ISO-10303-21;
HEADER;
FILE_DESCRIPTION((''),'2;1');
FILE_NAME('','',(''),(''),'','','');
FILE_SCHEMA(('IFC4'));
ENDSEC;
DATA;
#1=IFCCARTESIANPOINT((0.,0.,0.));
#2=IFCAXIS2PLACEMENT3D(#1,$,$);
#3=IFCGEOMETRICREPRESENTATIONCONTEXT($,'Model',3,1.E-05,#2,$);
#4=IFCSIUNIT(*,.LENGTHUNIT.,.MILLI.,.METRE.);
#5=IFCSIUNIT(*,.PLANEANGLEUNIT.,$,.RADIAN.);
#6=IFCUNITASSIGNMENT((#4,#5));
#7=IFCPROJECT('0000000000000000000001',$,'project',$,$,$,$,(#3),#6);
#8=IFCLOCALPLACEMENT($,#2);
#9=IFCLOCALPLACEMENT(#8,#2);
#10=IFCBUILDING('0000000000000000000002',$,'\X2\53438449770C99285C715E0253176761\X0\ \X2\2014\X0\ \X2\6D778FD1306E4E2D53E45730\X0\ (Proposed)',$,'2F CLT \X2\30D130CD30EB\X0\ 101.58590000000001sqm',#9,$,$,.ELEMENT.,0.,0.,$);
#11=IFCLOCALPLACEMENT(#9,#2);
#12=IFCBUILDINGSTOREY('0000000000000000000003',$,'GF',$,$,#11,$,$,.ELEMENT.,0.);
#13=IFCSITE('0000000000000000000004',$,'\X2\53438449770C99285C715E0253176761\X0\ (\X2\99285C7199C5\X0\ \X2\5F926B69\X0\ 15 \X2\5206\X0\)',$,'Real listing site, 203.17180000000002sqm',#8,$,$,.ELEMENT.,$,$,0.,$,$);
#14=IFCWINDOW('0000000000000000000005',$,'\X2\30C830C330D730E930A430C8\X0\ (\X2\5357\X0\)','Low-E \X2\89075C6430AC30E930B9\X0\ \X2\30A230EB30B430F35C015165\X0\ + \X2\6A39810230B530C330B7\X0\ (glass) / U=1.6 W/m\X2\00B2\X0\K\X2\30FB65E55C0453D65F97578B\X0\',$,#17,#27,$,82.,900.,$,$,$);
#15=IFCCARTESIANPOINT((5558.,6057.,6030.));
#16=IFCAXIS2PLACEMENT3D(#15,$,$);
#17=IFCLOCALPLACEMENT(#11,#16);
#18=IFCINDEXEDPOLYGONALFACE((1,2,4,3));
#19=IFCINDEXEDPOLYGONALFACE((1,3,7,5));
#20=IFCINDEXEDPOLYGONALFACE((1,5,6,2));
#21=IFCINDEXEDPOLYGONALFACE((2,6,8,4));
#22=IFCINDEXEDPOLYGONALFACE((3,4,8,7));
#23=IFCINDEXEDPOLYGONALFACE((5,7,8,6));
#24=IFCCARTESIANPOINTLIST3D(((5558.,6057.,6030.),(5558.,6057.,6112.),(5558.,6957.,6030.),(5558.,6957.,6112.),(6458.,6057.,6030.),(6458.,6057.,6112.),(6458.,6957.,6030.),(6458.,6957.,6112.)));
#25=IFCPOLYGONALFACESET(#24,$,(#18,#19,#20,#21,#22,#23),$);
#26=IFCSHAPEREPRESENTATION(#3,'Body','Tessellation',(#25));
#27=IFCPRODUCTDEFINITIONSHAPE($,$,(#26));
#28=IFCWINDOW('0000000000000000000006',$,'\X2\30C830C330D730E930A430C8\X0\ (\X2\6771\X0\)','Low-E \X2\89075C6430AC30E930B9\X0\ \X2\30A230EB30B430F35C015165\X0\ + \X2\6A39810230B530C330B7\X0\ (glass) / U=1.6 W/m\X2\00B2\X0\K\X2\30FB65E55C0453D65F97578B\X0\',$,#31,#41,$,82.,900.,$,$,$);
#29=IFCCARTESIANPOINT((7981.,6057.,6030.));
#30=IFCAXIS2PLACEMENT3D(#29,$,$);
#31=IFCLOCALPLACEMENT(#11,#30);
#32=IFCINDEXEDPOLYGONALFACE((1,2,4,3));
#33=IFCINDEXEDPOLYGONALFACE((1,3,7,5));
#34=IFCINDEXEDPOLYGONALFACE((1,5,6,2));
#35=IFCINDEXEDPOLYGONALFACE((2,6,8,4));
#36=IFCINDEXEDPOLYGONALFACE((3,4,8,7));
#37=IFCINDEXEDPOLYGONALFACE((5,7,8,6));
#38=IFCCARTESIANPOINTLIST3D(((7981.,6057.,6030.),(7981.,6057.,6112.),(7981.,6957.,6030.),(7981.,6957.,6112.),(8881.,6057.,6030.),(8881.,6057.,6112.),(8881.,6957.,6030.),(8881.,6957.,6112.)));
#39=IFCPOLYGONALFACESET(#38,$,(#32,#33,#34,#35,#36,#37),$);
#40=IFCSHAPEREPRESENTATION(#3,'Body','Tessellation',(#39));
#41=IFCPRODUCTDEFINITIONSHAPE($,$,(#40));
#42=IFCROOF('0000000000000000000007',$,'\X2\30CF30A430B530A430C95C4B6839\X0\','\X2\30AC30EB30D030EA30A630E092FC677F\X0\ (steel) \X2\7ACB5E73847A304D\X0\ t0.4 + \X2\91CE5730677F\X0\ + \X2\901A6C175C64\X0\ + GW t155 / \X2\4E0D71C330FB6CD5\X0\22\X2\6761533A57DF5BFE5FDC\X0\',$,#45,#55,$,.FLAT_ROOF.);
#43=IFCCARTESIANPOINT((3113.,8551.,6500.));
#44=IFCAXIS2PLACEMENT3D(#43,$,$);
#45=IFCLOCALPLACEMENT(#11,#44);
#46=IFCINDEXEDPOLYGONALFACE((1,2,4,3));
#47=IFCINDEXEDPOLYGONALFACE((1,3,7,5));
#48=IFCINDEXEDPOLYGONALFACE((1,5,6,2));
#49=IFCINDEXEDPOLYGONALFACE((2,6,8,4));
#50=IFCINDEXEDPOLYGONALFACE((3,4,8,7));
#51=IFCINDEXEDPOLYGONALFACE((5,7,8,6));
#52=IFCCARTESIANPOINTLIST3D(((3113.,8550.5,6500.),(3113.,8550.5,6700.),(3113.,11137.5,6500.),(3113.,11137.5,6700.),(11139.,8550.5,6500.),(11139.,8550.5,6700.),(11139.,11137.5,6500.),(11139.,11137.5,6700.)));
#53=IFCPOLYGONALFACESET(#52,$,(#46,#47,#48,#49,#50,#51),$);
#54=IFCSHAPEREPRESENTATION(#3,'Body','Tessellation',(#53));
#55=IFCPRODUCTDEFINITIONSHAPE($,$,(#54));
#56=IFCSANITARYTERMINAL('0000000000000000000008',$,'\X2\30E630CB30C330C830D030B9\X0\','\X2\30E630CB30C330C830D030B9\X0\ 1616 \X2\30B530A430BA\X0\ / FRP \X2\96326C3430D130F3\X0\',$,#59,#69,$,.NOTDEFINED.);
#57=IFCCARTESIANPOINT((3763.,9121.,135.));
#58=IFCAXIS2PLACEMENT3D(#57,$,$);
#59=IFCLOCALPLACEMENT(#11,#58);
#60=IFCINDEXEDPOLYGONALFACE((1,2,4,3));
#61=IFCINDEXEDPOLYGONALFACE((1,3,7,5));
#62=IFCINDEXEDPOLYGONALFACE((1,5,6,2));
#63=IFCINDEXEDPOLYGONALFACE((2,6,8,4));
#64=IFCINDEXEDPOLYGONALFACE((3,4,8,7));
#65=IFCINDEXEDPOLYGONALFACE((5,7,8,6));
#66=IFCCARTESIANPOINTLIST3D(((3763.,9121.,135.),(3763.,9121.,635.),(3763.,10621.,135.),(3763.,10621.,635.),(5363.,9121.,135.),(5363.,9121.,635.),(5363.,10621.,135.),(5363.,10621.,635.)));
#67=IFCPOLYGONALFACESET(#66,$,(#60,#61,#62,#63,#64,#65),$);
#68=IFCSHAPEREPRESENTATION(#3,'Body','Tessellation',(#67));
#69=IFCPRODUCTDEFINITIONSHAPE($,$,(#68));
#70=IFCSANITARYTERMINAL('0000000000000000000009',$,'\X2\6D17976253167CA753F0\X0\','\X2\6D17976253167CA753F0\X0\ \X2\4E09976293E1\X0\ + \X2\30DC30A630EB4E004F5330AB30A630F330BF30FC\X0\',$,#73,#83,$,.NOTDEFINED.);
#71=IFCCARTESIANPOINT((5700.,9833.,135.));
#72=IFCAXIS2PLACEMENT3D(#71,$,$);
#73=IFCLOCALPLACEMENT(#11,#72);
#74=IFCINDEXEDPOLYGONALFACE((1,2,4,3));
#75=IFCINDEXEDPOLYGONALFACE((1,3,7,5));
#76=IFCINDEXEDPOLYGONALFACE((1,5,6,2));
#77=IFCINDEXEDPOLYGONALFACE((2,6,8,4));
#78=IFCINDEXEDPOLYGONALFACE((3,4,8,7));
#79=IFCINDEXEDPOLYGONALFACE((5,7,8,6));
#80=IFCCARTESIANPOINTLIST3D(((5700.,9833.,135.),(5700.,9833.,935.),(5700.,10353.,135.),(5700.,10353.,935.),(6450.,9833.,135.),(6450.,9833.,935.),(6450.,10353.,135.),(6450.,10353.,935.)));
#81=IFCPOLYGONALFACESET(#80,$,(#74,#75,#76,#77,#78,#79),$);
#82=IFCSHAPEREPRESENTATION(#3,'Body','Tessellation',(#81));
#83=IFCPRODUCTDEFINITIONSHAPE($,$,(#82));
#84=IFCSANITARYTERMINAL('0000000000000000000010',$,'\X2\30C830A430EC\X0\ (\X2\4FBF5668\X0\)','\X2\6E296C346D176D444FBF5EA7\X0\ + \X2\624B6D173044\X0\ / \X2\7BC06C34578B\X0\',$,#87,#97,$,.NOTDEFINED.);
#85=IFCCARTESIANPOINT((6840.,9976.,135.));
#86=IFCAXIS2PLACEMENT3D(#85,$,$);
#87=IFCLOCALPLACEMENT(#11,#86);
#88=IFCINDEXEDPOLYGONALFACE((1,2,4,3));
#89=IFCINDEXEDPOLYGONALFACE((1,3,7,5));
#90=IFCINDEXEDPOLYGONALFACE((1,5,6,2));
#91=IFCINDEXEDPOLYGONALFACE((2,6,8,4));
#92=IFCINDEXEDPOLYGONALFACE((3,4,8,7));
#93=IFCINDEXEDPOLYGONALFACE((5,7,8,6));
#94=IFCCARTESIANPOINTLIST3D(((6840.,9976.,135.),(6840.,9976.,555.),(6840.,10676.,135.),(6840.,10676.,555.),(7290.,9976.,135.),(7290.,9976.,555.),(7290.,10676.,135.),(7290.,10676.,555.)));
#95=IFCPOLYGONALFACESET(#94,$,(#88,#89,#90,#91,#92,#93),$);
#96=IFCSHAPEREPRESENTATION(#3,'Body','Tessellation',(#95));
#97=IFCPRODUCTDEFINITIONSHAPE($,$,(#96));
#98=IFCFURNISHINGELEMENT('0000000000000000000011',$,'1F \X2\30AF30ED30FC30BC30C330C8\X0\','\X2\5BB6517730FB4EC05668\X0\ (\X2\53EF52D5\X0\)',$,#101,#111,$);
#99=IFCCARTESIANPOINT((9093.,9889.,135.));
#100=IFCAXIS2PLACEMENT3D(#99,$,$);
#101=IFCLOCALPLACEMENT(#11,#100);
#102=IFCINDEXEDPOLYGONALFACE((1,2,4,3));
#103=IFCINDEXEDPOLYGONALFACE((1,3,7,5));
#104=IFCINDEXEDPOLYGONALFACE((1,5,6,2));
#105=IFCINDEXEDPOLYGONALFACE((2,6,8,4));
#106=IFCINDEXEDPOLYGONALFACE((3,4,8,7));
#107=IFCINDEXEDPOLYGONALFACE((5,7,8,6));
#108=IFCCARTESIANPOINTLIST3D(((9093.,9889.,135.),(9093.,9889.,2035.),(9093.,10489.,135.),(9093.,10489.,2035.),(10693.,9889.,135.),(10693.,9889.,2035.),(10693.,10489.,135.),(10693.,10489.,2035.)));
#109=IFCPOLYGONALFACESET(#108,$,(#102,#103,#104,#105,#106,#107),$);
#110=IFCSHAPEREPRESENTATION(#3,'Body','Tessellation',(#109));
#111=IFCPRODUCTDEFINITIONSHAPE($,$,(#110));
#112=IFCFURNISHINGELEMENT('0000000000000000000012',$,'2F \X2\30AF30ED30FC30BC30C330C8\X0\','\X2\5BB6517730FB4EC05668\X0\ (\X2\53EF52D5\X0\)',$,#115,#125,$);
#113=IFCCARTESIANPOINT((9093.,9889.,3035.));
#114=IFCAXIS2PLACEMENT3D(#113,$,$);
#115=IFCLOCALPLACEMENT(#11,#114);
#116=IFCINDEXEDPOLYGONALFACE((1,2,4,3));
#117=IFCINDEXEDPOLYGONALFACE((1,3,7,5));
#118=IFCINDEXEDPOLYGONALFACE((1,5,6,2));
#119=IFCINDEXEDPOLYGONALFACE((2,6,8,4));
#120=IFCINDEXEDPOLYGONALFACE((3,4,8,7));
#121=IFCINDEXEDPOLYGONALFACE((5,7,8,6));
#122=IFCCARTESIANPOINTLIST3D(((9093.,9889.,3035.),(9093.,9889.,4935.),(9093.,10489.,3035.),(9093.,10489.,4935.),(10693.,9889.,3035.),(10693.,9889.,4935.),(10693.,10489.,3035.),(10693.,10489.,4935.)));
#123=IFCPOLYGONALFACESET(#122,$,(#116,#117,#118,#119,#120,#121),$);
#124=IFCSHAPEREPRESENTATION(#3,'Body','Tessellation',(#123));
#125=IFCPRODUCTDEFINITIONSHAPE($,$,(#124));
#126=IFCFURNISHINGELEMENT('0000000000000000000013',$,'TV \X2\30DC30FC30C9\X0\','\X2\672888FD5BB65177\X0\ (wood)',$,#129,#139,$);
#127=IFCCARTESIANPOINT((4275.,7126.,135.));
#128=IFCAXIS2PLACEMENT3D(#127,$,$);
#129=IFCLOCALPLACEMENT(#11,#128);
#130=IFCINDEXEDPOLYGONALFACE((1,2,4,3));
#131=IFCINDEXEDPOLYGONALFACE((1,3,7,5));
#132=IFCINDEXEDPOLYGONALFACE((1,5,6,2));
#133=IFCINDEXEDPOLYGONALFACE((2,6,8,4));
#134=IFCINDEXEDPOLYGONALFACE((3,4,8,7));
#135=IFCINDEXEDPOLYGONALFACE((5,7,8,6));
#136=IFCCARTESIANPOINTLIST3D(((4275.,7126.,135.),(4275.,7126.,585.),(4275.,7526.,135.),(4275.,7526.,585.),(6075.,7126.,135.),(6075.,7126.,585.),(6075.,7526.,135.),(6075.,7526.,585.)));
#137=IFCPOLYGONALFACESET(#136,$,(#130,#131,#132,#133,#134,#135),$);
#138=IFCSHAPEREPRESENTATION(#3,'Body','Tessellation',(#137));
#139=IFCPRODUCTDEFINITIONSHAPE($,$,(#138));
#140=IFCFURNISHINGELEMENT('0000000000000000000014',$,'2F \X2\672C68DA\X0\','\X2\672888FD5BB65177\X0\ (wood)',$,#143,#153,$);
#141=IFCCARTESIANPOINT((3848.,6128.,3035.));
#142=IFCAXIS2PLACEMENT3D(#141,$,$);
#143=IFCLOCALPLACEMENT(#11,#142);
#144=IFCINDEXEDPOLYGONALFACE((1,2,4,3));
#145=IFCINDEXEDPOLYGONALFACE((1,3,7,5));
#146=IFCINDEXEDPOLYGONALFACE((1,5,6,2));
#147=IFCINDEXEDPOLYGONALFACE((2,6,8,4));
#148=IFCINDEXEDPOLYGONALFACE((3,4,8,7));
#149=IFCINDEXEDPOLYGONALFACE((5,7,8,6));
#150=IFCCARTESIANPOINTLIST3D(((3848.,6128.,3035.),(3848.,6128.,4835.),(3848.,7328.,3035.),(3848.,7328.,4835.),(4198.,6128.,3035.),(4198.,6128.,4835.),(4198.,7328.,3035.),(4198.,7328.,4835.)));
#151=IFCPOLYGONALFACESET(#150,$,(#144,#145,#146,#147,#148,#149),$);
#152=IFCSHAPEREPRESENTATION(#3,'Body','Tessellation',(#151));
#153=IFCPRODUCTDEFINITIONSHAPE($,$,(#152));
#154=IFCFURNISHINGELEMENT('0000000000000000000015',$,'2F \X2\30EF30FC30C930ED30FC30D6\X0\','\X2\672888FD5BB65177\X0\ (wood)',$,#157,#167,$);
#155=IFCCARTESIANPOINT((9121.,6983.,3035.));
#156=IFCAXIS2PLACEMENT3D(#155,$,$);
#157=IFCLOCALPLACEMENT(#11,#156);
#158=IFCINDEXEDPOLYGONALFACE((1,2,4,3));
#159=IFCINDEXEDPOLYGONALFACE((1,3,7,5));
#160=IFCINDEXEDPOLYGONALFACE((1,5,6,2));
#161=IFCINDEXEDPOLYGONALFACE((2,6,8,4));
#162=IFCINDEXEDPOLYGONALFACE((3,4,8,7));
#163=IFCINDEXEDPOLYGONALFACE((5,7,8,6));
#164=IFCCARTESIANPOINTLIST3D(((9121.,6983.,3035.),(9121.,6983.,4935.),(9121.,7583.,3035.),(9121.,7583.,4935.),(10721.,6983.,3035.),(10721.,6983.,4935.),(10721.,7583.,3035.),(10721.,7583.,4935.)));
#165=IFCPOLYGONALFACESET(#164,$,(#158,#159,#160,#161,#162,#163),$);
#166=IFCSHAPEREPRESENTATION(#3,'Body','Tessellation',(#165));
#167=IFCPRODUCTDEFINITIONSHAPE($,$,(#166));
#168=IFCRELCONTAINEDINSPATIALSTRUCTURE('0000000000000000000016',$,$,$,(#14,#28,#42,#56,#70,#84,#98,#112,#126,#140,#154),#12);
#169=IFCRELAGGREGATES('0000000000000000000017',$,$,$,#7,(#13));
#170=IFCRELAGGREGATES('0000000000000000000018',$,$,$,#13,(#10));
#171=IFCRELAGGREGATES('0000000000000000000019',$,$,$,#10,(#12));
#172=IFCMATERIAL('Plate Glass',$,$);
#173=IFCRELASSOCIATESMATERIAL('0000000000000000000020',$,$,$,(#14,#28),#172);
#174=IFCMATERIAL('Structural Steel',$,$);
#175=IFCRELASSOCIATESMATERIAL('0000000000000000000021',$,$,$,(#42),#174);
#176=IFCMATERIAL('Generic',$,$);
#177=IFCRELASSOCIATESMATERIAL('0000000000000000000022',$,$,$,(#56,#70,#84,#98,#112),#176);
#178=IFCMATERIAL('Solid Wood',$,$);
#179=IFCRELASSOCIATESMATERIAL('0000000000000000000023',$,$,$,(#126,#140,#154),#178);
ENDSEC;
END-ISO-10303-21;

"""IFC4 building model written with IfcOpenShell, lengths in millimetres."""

from ifc_helpers import new_model, si_unit, frame, frame_2d, origin, place, context, project, spatial, rectangle, extrude, material, element, save


model = new_model("IFC4")

# Units and contexts
model_context = context("Model", 3, precision=1e-05, world=origin())
ifc_project = project(units=[si_unit("LENGTHUNIT", "METRE", prefix="MILLI"), si_unit("PLANEANGLEUNIT", "RADIAN")], contexts=[model_context])

# Site, building, storey
site_placement = place(None, origin())
site = spatial("IfcSite", under=ifc_project, at=site_placement, Name="千葉県館山市北条 (館山駅 徒歩 15 分)", ObjectType="Real listing site, 203.17180000000002sqm", CompositionType="ELEMENT", RefElevation=0.0)
building_placement = place(site_placement, origin())
building = spatial("IfcBuilding", under=site, at=building_placement, Name="千葉県館山市北条 — 海近の中古地 (Proposed)", ObjectType="2F CLT パネル 101.58590000000001sqm", CompositionType="ELEMENT", ElevationOfRefHeight=0.0, ElevationOfTerrain=0.0)
storey_placement = place(building_placement, origin())
storey = spatial("IfcBuildingStorey", under=building, at=storey_placement, Name="GF", CompositionType="ELEMENT", Elevation=0.0)

# Shared definitions
ifc_material_1 = material(Name="Solid Wood")
ifc_material_2 = material(Name="Plate Glass")

# Windows
window_1_placement = place(storey_placement, frame((5558.0, 6057.0, 6030.0)))
element("IfcWindow", 1, at=window_1_placement, inside=storey, material=ifc_material_2, Name="トップライト (南)", Description="Low-E 複層ガラス アルゴン封入 + 樹脂サッシ (glass) / U=1.6 W/m²K・日射取得型", OverallHeight=82.0, OverallWidth=900.0, context=model_context, shape_type="SweptSolid", body=[
    extrude(rectangle(XDim=900.0, YDim=900.0, at=frame_2d((450.0, 450.0))), frame((5558.0, 6057.0, 6030.0)), (0.0, 0.0, 1.0), 82.0),
])
window_2_placement = place(storey_placement, frame((7981.0, 6057.0, 6030.0)))
element("IfcWindow", 2, at=window_2_placement, inside=storey, material=ifc_material_2, Name="トップライト (東)", Description="Low-E 複層ガラス アルゴン封入 + 樹脂サッシ (glass) / U=1.6 W/m²K・日射取得型", OverallHeight=82.0, OverallWidth=900.0, context=model_context, shape_type="SweptSolid", body=[
    extrude(rectangle(XDim=900.0, YDim=900.0, at=frame_2d((450.0, 450.0))), frame((7981.0, 6057.0, 6030.0)), (0.0, 0.0, 1.0), 82.0),
])

# Roof
ifc_material_3 = material(Name="Structural Steel")
roof_placement = place(storey_placement, frame((3113.0, 8551.0, 6500.0)))
element("IfcRoof", 3, at=roof_placement, inside=storey, material=ifc_material_3, Name="ハイサイド屋根", Description="ガルバリウム鋼板 (steel) 立平葺き t0.4 + 野地板 + 通気層 + GW t155 / 不燃・法22条区域対応", PredefinedType="FLAT_ROOF", context=model_context, shape_type="SweptSolid", body=[
    extrude(rectangle(XDim=8026.0, YDim=2587.0, at=frame_2d((4013.0, 1293.0))), frame((3113.0, 8551.0, 6500.0)), (0.0, 0.0, 1.0), 200.0),
])

# Sanitary terminals
ifc_material_4 = material(Name="Generic")
sanitary_terminal_1_placement = place(storey_placement, frame((3763.0, 9121.0, 135.0)))
element("IfcSanitaryTerminal", 4, at=sanitary_terminal_1_placement, inside=storey, material=ifc_material_4, Name="ユニットバス", Description="ユニットバス 1616 サイズ / FRP 防水パン", PredefinedType="NOTDEFINED", context=model_context, shape_type="SweptSolid", body=[
    extrude(rectangle(XDim=1600.0, YDim=1500.0, at=frame_2d((800.0, 750.0))), frame((3763.0, 9121.0, 135.0)), (0.0, 0.0, 1.0), 500.0),
])
sanitary_terminal_2_placement = place(storey_placement, frame((5700.0, 9833.0, 135.0)))
element("IfcSanitaryTerminal", 5, at=sanitary_terminal_2_placement, inside=storey, material=ifc_material_4, Name="洗面化粧台", Description="洗面化粧台 三面鏡 + ボウル一体カウンター", PredefinedType="NOTDEFINED", context=model_context, shape_type="SweptSolid", body=[
    extrude(rectangle(XDim=750.0, YDim=520.0, at=frame_2d((375.0, 260.0))), frame((5700.0, 9833.0, 135.0)), (0.0, 0.0, 1.0), 800.0),
])
sanitary_terminal_3_placement = place(storey_placement, frame((6840.0, 9976.0, 135.0)))
element("IfcSanitaryTerminal", 6, at=sanitary_terminal_3_placement, inside=storey, material=ifc_material_4, Name="トイレ (便器)", Description="温水洗浄便座 + 手洗い / 節水型", PredefinedType="NOTDEFINED", context=model_context, shape_type="SweptSolid", body=[
    extrude(rectangle(XDim=450.0, YDim=700.0, at=frame_2d((225.0, 350.0))), frame((6840.0, 9976.0, 135.0)), (0.0, 0.0, 1.0), 420.0),
])

# Furnishing elements
furnishing_1_placement = place(storey_placement, frame((9093.0, 9889.0, 135.0)))
element("IfcFurnishingElement", 7, at=furnishing_1_placement, inside=storey, material=ifc_material_4, Name="1F クローゼット", Description="家具・什器 (可動)", context=model_context, shape_type="SweptSolid", body=[
    extrude(rectangle(XDim=1600.0, YDim=600.0, at=frame_2d((800.0, 300.0))), frame((9093.0, 9889.0, 135.0)), (0.0, 0.0, 1.0), 1900.0),
])
furnishing_2_placement = place(storey_placement, frame((9093.0, 9889.0, 3035.0)))
element("IfcFurnishingElement", 8, at=furnishing_2_placement, inside=storey, material=ifc_material_4, Name="2F クローゼット", Description="家具・什器 (可動)", context=model_context, shape_type="SweptSolid", body=[
    extrude(rectangle(XDim=1600.0, YDim=600.0, at=frame_2d((800.0, 300.0))), frame((9093.0, 9889.0, 3035.0)), (0.0, 0.0, 1.0), 1900.0),
])
furnishing_3_placement = place(storey_placement, frame((4275.0, 7126.0, 135.0)))
element("IfcFurnishingElement", 9, at=furnishing_3_placement, inside=storey, material=ifc_material_1, Name="TV ボード", Description="木製家具 (wood)", context=model_context, shape_type="SweptSolid", body=[
    extrude(rectangle(XDim=1800.0, YDim=400.0, at=frame_2d((900.0, 200.0))), frame((4275.0, 7126.0, 135.0)), (0.0, 0.0, 1.0), 450.0),
])
furnishing_4_placement = place(storey_placement, frame((3848.0, 6128.0, 3035.0)))
element("IfcFurnishingElement", 10, at=furnishing_4_placement, inside=storey, material=ifc_material_1, Name="2F 本棚", Description="木製家具 (wood)", context=model_context, shape_type="SweptSolid", body=[
    extrude(rectangle(XDim=350.0, YDim=1200.0, at=frame_2d((175.0, 600.0))), frame((3848.0, 6128.0, 3035.0)), (0.0, 0.0, 1.0), 1800.0),
])
furnishing_5_placement = place(storey_placement, frame((9121.0, 6983.0, 3035.0)))
element("IfcFurnishingElement", 11, at=furnishing_5_placement, inside=storey, material=ifc_material_1, Name="2F ワードローブ", Description="木製家具 (wood)", context=model_context, shape_type="SweptSolid", body=[
    extrude(rectangle(XDim=1600.0, YDim=600.0, at=frame_2d((800.0, 300.0))), frame((9121.0, 6983.0, 3035.0)), (0.0, 0.0, 1.0), 1900.0),
])

save(model, "model.ifc")
